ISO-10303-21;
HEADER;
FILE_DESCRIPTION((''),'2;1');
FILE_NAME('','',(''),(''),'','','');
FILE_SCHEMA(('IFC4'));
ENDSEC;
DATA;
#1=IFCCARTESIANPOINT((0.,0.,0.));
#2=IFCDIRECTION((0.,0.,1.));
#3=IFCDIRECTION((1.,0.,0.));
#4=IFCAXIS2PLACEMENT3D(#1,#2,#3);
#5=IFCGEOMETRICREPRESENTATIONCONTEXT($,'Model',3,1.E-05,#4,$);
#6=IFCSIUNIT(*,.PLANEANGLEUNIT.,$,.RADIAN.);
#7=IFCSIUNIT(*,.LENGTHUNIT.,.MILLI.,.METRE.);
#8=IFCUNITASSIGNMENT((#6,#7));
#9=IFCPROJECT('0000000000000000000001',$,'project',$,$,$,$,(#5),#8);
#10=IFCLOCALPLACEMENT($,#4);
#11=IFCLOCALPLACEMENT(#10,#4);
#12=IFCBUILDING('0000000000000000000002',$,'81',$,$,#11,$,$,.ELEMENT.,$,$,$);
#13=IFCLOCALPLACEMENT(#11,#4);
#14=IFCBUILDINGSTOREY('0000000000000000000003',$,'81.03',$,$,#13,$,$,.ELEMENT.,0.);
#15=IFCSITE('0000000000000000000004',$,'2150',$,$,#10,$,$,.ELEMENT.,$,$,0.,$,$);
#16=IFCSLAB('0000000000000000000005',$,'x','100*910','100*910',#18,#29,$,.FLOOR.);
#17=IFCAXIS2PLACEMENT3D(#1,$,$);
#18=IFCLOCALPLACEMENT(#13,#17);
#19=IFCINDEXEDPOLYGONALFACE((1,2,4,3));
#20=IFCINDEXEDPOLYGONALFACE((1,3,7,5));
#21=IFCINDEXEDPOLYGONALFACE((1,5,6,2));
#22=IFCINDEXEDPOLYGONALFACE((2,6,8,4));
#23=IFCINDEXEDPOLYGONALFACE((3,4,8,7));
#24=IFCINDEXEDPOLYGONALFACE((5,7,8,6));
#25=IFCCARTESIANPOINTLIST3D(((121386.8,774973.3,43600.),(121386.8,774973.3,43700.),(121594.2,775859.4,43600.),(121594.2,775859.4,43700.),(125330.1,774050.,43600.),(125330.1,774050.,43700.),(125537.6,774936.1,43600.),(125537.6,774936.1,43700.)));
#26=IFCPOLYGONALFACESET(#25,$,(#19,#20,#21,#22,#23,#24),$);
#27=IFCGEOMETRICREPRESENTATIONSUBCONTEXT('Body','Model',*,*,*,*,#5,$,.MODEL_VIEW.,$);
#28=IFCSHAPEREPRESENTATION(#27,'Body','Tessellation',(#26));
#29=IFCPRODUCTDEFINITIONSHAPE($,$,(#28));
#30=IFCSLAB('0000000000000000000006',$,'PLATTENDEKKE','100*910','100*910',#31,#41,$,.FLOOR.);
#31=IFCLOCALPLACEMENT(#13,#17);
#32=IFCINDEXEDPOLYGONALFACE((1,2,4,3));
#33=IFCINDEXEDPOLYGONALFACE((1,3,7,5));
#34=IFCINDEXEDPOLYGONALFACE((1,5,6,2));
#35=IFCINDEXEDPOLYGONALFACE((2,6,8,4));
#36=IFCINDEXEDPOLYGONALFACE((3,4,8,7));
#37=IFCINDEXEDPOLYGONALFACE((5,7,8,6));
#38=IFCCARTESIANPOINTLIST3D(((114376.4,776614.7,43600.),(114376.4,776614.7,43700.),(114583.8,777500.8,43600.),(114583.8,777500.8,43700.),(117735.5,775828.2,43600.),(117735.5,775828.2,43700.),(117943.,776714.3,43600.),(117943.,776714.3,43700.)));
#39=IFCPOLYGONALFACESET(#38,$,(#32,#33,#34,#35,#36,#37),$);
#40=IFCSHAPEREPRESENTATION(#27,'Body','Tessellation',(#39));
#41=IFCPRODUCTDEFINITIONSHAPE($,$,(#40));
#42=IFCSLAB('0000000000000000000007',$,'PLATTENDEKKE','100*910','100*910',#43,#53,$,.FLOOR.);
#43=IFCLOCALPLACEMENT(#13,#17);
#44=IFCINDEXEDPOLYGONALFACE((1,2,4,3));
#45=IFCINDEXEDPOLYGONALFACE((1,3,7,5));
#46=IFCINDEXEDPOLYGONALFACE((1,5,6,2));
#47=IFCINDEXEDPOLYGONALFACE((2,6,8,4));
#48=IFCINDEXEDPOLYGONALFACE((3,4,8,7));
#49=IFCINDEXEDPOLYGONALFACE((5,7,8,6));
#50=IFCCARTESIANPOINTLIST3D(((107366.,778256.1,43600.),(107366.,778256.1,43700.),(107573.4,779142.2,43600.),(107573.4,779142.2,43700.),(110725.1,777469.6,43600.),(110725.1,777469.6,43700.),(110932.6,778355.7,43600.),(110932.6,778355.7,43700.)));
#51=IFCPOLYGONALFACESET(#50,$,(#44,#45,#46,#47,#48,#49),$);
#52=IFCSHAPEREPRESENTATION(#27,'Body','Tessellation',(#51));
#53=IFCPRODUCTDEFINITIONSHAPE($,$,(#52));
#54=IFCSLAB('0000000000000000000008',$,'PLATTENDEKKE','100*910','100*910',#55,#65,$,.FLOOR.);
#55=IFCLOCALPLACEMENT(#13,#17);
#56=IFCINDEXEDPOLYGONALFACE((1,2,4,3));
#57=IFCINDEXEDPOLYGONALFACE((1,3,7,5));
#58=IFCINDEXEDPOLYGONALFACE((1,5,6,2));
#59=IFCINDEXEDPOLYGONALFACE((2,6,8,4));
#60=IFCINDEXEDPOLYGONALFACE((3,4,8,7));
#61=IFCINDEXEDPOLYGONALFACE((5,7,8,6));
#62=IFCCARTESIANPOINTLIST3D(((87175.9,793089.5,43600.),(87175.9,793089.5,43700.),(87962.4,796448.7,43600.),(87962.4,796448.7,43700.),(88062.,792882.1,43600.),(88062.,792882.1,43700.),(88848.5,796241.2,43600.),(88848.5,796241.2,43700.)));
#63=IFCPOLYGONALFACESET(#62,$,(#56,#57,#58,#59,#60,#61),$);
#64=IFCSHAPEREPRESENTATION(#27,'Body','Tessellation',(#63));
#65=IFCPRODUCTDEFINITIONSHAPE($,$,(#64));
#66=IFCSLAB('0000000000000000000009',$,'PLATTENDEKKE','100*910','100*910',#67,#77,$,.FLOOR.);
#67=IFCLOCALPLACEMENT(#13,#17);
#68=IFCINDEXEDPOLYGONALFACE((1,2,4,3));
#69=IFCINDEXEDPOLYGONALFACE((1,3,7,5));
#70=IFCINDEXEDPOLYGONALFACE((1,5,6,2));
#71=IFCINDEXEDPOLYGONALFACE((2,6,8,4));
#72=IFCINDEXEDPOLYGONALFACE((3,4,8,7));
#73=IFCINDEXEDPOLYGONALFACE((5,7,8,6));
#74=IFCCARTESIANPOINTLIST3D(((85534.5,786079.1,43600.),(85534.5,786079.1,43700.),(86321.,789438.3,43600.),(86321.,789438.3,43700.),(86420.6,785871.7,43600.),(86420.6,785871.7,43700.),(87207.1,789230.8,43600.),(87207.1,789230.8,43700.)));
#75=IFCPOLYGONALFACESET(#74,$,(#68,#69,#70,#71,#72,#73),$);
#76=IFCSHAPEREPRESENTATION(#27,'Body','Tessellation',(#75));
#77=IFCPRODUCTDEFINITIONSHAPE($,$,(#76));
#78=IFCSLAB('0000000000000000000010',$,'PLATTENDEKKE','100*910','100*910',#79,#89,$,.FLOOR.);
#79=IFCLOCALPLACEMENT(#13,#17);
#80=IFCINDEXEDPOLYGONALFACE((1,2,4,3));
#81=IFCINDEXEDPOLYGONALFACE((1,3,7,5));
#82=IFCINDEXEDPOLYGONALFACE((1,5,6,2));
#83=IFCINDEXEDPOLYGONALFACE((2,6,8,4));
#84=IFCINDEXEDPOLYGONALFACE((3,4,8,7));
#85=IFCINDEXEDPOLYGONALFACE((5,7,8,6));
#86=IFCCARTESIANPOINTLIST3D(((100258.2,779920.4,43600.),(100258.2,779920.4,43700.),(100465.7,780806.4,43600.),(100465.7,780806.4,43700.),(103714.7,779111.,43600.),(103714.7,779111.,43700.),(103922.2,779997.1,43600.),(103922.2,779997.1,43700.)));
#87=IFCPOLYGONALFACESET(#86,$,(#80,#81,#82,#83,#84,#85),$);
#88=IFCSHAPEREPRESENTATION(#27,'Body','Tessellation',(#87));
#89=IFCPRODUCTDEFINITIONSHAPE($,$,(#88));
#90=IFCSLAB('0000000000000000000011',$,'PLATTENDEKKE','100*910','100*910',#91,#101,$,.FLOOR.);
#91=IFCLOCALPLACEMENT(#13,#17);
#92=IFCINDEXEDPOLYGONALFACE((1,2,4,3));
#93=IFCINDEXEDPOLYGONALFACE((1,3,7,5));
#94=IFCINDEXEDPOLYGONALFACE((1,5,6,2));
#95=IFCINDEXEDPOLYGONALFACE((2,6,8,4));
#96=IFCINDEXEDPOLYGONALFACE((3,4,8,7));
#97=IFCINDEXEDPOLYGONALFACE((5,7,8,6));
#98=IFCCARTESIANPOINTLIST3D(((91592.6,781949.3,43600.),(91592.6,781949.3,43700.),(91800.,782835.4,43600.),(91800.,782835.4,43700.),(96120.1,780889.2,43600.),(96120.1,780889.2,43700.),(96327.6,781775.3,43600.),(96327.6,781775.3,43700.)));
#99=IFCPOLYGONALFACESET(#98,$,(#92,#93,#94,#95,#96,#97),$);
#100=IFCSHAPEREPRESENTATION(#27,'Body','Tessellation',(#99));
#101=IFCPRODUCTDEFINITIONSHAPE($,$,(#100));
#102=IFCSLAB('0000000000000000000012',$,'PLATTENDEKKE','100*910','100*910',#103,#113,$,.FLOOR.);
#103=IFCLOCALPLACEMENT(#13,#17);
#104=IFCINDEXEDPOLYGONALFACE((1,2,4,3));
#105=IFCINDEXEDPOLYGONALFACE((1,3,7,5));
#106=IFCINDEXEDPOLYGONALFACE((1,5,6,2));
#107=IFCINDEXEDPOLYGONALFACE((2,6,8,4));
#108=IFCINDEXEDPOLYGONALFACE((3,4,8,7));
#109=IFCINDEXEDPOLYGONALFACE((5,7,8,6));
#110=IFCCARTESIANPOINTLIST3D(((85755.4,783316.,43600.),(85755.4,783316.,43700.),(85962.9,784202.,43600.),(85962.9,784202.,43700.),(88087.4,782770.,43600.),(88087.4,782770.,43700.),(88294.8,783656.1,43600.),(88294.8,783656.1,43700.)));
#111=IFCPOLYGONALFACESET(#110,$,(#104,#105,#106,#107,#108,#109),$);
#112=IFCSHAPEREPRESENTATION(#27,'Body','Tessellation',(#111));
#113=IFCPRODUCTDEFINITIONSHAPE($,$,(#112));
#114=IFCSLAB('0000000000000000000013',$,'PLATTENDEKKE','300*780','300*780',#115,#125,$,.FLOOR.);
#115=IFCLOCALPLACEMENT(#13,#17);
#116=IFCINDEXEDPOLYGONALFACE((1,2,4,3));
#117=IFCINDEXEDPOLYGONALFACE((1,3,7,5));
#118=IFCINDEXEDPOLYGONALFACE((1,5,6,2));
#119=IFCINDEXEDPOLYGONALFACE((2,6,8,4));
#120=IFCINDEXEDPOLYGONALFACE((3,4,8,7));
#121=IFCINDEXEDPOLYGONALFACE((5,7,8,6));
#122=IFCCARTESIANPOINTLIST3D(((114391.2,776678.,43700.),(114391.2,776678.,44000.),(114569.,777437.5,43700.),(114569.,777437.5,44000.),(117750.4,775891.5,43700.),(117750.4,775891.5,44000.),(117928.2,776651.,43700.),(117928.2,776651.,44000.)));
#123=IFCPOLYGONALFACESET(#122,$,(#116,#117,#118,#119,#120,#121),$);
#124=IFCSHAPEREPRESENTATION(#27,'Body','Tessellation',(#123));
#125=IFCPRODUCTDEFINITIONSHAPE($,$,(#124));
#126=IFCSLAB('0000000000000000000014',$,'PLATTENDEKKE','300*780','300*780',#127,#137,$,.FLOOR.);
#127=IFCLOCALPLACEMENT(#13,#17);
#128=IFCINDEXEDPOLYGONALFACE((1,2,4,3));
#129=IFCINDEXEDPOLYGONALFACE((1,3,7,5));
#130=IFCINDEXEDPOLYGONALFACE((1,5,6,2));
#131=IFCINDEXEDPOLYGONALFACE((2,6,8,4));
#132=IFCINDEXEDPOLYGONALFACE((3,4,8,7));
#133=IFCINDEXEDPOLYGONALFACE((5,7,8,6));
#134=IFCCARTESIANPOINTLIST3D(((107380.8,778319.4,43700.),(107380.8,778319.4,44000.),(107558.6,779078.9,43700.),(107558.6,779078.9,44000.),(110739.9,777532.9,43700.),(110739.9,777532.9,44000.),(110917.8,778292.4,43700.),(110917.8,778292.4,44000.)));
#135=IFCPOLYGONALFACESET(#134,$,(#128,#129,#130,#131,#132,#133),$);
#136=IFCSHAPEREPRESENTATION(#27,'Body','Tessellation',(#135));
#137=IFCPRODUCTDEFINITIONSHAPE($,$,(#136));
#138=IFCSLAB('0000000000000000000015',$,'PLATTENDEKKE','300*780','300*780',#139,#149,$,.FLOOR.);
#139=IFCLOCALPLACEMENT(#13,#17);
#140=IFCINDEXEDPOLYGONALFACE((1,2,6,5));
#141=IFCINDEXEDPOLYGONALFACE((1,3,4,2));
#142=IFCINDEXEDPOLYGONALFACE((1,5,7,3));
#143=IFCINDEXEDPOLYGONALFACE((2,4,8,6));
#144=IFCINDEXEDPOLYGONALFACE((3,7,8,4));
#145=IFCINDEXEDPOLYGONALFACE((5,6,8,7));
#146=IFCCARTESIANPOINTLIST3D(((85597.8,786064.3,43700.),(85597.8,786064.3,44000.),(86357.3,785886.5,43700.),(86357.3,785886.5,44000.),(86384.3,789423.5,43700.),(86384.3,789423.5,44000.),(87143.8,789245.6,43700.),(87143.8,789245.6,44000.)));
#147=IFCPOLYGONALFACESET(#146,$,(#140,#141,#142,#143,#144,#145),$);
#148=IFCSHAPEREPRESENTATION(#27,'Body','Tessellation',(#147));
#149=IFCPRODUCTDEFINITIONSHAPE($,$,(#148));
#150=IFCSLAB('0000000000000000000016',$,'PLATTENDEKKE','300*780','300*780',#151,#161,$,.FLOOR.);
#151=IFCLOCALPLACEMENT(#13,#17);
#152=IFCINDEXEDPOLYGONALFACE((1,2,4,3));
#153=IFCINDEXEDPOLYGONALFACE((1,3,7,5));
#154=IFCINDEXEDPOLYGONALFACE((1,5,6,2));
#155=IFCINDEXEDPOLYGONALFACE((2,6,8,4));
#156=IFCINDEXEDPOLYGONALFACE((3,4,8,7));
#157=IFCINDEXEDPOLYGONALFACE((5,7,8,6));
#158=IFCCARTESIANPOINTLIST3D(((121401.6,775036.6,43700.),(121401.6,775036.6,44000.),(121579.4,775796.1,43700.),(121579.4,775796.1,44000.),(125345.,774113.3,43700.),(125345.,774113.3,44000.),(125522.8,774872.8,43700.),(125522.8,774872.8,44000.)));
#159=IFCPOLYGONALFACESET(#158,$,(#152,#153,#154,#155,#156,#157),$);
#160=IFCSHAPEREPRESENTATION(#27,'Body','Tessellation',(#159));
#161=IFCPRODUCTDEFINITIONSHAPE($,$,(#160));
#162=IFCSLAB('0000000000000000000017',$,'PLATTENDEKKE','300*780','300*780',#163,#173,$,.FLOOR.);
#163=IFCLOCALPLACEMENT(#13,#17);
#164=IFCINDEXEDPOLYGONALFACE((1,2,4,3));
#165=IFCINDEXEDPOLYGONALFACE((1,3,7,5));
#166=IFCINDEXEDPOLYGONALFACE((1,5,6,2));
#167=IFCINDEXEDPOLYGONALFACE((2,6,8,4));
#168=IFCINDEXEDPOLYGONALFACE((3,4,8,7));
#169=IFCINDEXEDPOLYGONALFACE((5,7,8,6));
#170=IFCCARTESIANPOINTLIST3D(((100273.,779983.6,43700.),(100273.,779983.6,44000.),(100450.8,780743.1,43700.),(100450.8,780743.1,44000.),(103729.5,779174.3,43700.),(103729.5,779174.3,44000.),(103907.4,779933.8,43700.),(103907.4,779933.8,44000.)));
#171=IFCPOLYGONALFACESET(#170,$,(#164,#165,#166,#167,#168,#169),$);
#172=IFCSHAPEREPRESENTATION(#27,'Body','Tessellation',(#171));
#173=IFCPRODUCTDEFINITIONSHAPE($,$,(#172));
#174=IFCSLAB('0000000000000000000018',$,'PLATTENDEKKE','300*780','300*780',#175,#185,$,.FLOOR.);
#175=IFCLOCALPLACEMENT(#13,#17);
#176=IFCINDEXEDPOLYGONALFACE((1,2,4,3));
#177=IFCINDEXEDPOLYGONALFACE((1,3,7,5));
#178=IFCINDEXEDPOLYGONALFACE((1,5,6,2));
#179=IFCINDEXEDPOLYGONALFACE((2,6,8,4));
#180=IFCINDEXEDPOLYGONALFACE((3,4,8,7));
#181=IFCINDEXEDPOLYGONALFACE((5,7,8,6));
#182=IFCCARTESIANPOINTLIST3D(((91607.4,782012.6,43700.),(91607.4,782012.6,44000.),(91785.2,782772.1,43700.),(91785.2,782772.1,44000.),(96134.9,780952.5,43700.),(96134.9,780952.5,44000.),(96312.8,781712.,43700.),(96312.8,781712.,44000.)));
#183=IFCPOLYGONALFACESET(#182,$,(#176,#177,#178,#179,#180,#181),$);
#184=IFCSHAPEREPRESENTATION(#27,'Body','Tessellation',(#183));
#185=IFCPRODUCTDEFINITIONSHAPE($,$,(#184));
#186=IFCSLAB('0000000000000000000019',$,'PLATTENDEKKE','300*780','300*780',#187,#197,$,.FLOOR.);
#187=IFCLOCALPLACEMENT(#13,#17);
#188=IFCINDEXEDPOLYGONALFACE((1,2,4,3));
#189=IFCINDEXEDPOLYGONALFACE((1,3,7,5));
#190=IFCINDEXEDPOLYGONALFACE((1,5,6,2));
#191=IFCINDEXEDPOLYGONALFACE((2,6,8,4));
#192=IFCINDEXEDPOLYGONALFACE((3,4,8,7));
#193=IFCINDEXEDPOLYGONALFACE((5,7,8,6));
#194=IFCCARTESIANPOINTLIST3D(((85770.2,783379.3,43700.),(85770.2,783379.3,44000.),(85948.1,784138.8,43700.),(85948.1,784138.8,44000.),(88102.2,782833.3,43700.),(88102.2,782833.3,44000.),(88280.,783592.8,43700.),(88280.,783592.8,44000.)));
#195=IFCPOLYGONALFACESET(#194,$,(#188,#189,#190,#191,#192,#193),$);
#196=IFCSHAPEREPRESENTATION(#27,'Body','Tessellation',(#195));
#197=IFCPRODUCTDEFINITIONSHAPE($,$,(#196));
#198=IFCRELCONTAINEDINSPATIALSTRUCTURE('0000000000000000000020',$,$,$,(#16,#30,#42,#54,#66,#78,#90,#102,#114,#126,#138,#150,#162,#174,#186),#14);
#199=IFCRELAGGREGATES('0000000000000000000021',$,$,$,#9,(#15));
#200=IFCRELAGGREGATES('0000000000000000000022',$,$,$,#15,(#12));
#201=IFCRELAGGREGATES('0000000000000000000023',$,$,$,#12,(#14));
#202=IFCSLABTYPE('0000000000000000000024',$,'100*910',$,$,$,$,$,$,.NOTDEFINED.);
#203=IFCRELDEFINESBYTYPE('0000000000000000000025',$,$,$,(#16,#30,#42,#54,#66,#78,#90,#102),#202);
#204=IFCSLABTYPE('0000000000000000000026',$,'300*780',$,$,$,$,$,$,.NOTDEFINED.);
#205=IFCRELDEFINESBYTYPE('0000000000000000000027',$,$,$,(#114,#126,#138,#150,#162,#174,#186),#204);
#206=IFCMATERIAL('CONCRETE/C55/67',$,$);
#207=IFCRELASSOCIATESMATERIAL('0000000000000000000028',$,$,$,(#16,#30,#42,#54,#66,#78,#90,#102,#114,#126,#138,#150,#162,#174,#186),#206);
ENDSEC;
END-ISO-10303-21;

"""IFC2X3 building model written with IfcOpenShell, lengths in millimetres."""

from ifc_helpers import new_model, si_unit, frame, origin, origin_with_axes, origin_2d_with_axis, place, context, subcontext, project, spatial, rectangle, extrude, source, transform, mapped, material, type_object, element, save


model = new_model("IFC2X3")

# Units and contexts
model_context = context("Model", 3, precision=1e-05, world=origin_with_axes())
body_context = subcontext(model_context, "Body", "Model", "MODEL_VIEW")
ifc_project = project(units=[si_unit("PLANEANGLEUNIT", "RADIAN"), si_unit("LENGTHUNIT", "METRE", prefix="MILLI")], contexts=[model_context])

# Site, building, storey
site_placement = place(None, origin_with_axes())
site = spatial("IfcSite", under=ifc_project, at=site_placement, Name="2150", CompositionType="ELEMENT", RefElevation=0.0)
building_placement = place(site_placement, origin_with_axes())
building = spatial("IfcBuilding", under=site, at=building_placement, Name="81", CompositionType="ELEMENT")
storey_placement = place(building_placement, origin_with_axes())
storey = spatial("IfcBuildingStorey", under=building, at=storey_placement, Name="81.03", CompositionType="ELEMENT", Elevation=0.0)

# Slabs
ifc_material = material(Name="CONCRETE/C55/67")
slab_type_1 = type_object("IfcSlabType", Name="100*910", PredefinedType="NOTDEFINED")
shared_shape_1 = source(origin(), body_context, "Body", "SweptSolid", [
    extrude(rectangle(XDim=910.0, YDim=100.0, at=origin_2d_with_axis()), frame((4050.0, 0.0, 0.0), z_axis=(-1.0, 0.0, 0.0), x_axis=(0.0, -1.0, 0.0)), (0.0, 0.0, 1.0), 4050.0),
])
slab_1_placement = place(storey_placement, frame((121490.5, 775416.4, 43650.0), z_axis=(0.0, 0.0, 1.0), x_axis=(0.973667, -0.227974, 0.0)))
element("IfcSlab", 1, at=slab_1_placement, inside=storey, type_object=slab_type_1, material=ifc_material, Name="x", Description="100*910", ObjectType="100*910", PredefinedType="FLOOR", context=body_context, shape_type="MappedRepresentation", body=[
    mapped(shared_shape_1, transform((0.0, 0.0, 0.0))),
])
shared_shape_2 = source(origin(), body_context, "Body", "SweptSolid", [
    extrude(rectangle(XDim=910.0, YDim=100.0, at=origin_2d_with_axis()), frame((3450.0, 0.0, 0.0), z_axis=(-1.0, 0.0, 0.0), x_axis=(0.0, -1.0, 0.0)), (0.0, 0.0, 1.0), 3450.0),
])
for number, where, z_axis, x_axis, name in (
    (2, (114480.1, 777057.8, 43650.0), (0.0, 0.0, 1.0), (0.973667, -0.227974, 0.0), "PLATTENDEKKE"),
    (3, (107469.7, 778699.2, 43650.0), (0.0, 0.0, 1.0), (0.973667, -0.227974, 0.0), "PLATTENDEKKE"),
    (4, (88405.5, 796345.0, 43650.0), (0.0, 0.0, 1.0), (-0.227973, -0.973667, 0.0), "PLATTENDEKKE"),
    (5, (86764.1, 789334.5, 43650.0), (0.0, 0.0, 1.0), (-0.227973, -0.973667, 0.0), "PLATTENDEKKE"),
):
    element("IfcSlab", number, at=place(storey_placement, frame(where, z_axis=z_axis, x_axis=x_axis)), inside=storey, type_object=slab_type_1, material=ifc_material, Name=name, Description="100*910", ObjectType="100*910", PredefinedType="FLOOR", context=body_context, shape_type="MappedRepresentation", body=[
        mapped(shared_shape_2, transform((0.0, 0.0, 0.0))),
    ])
shared_shape_3 = source(origin(), body_context, "Body", "SweptSolid", [
    extrude(rectangle(XDim=910.0, YDim=100.0, at=origin_2d_with_axis()), frame((3550.0, 0.0, 0.0), z_axis=(-1.0, 0.0, 0.0), x_axis=(0.0, -1.0, 0.0)), (0.0, 0.0, 1.0), 3550.0),
])
slab_2_placement = place(storey_placement, frame((100361.9, 780363.4, 43650.0), z_axis=(0.0, 0.0, 1.0), x_axis=(0.973667, -0.227974, 0.0)))
element("IfcSlab", 6, at=slab_2_placement, inside=storey, type_object=slab_type_1, material=ifc_material, Name="PLATTENDEKKE", Description="100*910", ObjectType="100*910", PredefinedType="FLOOR", context=body_context, shape_type="MappedRepresentation", body=[
    mapped(shared_shape_3, transform((0.0, 0.0, 0.0))),
])
shared_shape_4 = source(origin(), body_context, "Body", "SweptSolid", [
    extrude(rectangle(XDim=910.0, YDim=100.0, at=origin_2d_with_axis()), frame((4650.0, 0.0, 0.0), z_axis=(-1.0, 0.0, 0.0), x_axis=(0.0, -1.0, 0.0)), (0.0, 0.0, 1.0), 4650.0),
])
slab_3_placement = place(storey_placement, frame((91696.3, 782392.3, 43650.0), z_axis=(0.0, 0.0, 1.0), x_axis=(0.973667, -0.227974, 0.0)))
element("IfcSlab", 7, at=slab_3_placement, inside=storey, type_object=slab_type_1, material=ifc_material, Name="PLATTENDEKKE", Description="100*910", ObjectType="100*910", PredefinedType="FLOOR", context=body_context, shape_type="MappedRepresentation", body=[
    mapped(shared_shape_4, transform((0.0, 0.0, 0.0))),
])
shared_shape_5 = source(origin(), body_context, "Body", "SweptSolid", [
    extrude(rectangle(XDim=910.0, YDim=100.0, at=origin_2d_with_axis()), frame((2395.0, 0.0, 0.0), z_axis=(-1.0, 0.0, 0.0), x_axis=(0.0, -1.0, 0.0)), (0.0, 0.0, 1.0), 2395.0),
])
slab_4_placement = place(storey_placement, frame((85859.2, 783759.0, 43650.0), z_axis=(0.0, 0.0, 1.0), x_axis=(0.973667, -0.227974, 0.0)))
element("IfcSlab", 8, at=slab_4_placement, inside=storey, type_object=slab_type_1, material=ifc_material, Name="PLATTENDEKKE", Description="100*910", ObjectType="100*910", PredefinedType="FLOOR", context=body_context, shape_type="MappedRepresentation", body=[
    mapped(shared_shape_5, transform((0.0, 0.0, 0.0))),
])
slab_type_2 = type_object("IfcSlabType", Name="300*780", PredefinedType="NOTDEFINED")
shared_shape_6 = source(origin(), body_context, "Body", "SweptSolid", [
    extrude(rectangle(XDim=780.0, YDim=300.0, at=origin_2d_with_axis()), frame((3450.0, 0.0, 0.0), z_axis=(-1.0, 0.0, 0.0), x_axis=(0.0, -1.0, 0.0)), (0.0, 0.0, 1.0), 3450.0),
])
for number, where, z_axis, x_axis, name in (
    (9, (114480.1, 777057.8, 43850.0), (0.0, 0.0, 1.0), (0.973667, -0.227974, 0.0), "PLATTENDEKKE"),
    (10, (107469.7, 778699.2, 43850.0), (0.0, 0.0, 1.0), (0.973667, -0.227974, 0.0), "PLATTENDEKKE"),
    (11, (86764.1, 789334.5, 43850.0), (0.0, 0.0, 1.0), (-0.227973, -0.973667, 0.0), "PLATTENDEKKE"),
):
    element("IfcSlab", number, at=place(storey_placement, frame(where, z_axis=z_axis, x_axis=x_axis)), inside=storey, type_object=slab_type_2, material=ifc_material, Name=name, Description="300*780", ObjectType="300*780", PredefinedType="FLOOR", context=body_context, shape_type="MappedRepresentation", body=[
        mapped(shared_shape_6, transform((0.0, 0.0, 0.0))),
    ])
shared_shape_7 = source(origin(), body_context, "Body", "SweptSolid", [
    extrude(rectangle(XDim=780.0, YDim=300.0, at=origin_2d_with_axis()), frame((4050.0, 0.0, 0.0), z_axis=(-1.0, 0.0, 0.0), x_axis=(0.0, -1.0, 0.0)), (0.0, 0.0, 1.0), 4050.0),
])
slab_5_placement = place(storey_placement, frame((121490.5, 775416.4, 43850.0), z_axis=(0.0, 0.0, 1.0), x_axis=(0.973667, -0.227974, 0.0)))
element("IfcSlab", 12, at=slab_5_placement, inside=storey, type_object=slab_type_2, material=ifc_material, Name="PLATTENDEKKE", Description="300*780", ObjectType="300*780", PredefinedType="FLOOR", context=body_context, shape_type="MappedRepresentation", body=[
    mapped(shared_shape_7, transform((0.0, 0.0, 0.0))),
])
shared_shape_8 = source(origin(), body_context, "Body", "SweptSolid", [
    extrude(rectangle(XDim=780.0, YDim=300.0, at=origin_2d_with_axis()), frame((3550.0, 0.0, 0.0), z_axis=(-1.0, 0.0, 0.0), x_axis=(0.0, -1.0, 0.0)), (0.0, 0.0, 1.0), 3550.0),
])
slab_6_placement = place(storey_placement, frame((100361.9, 780363.4, 43850.0), z_axis=(0.0, 0.0, 1.0), x_axis=(0.973667, -0.227974, 0.0)))
element("IfcSlab", 13, at=slab_6_placement, inside=storey, type_object=slab_type_2, material=ifc_material, Name="PLATTENDEKKE", Description="300*780", ObjectType="300*780", PredefinedType="FLOOR", context=body_context, shape_type="MappedRepresentation", body=[
    mapped(shared_shape_8, transform((0.0, 0.0, 0.0))),
])
shared_shape_9 = source(origin(), body_context, "Body", "SweptSolid", [
    extrude(rectangle(XDim=780.0, YDim=300.0, at=origin_2d_with_axis()), frame((4650.0, 0.0, 0.0), z_axis=(-1.0, 0.0, 0.0), x_axis=(0.0, -1.0, 0.0)), (0.0, 0.0, 1.0), 4650.0),
])
slab_7_placement = place(storey_placement, frame((91696.3, 782392.3, 43850.0), z_axis=(0.0, 0.0, 1.0), x_axis=(0.973667, -0.227974, 0.0)))
element("IfcSlab", 14, at=slab_7_placement, inside=storey, type_object=slab_type_2, material=ifc_material, Name="PLATTENDEKKE", Description="300*780", ObjectType="300*780", PredefinedType="FLOOR", context=body_context, shape_type="MappedRepresentation", body=[
    mapped(shared_shape_9, transform((0.0, 0.0, 0.0))),
])
shared_shape_10 = source(origin(), body_context, "Body", "SweptSolid", [
    extrude(rectangle(XDim=780.0, YDim=300.0, at=origin_2d_with_axis()), frame((2395.0, 0.0, 0.0), z_axis=(-1.0, 0.0, 0.0), x_axis=(0.0, -1.0, 0.0)), (0.0, 0.0, 1.0), 2395.0),
])
slab_8_placement = place(storey_placement, frame((85859.2, 783759.0, 43850.0), z_axis=(0.0, 0.0, 1.0), x_axis=(0.973667, -0.227974, 0.0)))
element("IfcSlab", 15, at=slab_8_placement, inside=storey, type_object=slab_type_2, material=ifc_material, Name="PLATTENDEKKE", Description="300*780", ObjectType="300*780", PredefinedType="FLOOR", context=body_context, shape_type="MappedRepresentation", body=[
    mapped(shared_shape_10, transform((0.0, 0.0, 0.0))),
])

save(model, "model.ifc")
